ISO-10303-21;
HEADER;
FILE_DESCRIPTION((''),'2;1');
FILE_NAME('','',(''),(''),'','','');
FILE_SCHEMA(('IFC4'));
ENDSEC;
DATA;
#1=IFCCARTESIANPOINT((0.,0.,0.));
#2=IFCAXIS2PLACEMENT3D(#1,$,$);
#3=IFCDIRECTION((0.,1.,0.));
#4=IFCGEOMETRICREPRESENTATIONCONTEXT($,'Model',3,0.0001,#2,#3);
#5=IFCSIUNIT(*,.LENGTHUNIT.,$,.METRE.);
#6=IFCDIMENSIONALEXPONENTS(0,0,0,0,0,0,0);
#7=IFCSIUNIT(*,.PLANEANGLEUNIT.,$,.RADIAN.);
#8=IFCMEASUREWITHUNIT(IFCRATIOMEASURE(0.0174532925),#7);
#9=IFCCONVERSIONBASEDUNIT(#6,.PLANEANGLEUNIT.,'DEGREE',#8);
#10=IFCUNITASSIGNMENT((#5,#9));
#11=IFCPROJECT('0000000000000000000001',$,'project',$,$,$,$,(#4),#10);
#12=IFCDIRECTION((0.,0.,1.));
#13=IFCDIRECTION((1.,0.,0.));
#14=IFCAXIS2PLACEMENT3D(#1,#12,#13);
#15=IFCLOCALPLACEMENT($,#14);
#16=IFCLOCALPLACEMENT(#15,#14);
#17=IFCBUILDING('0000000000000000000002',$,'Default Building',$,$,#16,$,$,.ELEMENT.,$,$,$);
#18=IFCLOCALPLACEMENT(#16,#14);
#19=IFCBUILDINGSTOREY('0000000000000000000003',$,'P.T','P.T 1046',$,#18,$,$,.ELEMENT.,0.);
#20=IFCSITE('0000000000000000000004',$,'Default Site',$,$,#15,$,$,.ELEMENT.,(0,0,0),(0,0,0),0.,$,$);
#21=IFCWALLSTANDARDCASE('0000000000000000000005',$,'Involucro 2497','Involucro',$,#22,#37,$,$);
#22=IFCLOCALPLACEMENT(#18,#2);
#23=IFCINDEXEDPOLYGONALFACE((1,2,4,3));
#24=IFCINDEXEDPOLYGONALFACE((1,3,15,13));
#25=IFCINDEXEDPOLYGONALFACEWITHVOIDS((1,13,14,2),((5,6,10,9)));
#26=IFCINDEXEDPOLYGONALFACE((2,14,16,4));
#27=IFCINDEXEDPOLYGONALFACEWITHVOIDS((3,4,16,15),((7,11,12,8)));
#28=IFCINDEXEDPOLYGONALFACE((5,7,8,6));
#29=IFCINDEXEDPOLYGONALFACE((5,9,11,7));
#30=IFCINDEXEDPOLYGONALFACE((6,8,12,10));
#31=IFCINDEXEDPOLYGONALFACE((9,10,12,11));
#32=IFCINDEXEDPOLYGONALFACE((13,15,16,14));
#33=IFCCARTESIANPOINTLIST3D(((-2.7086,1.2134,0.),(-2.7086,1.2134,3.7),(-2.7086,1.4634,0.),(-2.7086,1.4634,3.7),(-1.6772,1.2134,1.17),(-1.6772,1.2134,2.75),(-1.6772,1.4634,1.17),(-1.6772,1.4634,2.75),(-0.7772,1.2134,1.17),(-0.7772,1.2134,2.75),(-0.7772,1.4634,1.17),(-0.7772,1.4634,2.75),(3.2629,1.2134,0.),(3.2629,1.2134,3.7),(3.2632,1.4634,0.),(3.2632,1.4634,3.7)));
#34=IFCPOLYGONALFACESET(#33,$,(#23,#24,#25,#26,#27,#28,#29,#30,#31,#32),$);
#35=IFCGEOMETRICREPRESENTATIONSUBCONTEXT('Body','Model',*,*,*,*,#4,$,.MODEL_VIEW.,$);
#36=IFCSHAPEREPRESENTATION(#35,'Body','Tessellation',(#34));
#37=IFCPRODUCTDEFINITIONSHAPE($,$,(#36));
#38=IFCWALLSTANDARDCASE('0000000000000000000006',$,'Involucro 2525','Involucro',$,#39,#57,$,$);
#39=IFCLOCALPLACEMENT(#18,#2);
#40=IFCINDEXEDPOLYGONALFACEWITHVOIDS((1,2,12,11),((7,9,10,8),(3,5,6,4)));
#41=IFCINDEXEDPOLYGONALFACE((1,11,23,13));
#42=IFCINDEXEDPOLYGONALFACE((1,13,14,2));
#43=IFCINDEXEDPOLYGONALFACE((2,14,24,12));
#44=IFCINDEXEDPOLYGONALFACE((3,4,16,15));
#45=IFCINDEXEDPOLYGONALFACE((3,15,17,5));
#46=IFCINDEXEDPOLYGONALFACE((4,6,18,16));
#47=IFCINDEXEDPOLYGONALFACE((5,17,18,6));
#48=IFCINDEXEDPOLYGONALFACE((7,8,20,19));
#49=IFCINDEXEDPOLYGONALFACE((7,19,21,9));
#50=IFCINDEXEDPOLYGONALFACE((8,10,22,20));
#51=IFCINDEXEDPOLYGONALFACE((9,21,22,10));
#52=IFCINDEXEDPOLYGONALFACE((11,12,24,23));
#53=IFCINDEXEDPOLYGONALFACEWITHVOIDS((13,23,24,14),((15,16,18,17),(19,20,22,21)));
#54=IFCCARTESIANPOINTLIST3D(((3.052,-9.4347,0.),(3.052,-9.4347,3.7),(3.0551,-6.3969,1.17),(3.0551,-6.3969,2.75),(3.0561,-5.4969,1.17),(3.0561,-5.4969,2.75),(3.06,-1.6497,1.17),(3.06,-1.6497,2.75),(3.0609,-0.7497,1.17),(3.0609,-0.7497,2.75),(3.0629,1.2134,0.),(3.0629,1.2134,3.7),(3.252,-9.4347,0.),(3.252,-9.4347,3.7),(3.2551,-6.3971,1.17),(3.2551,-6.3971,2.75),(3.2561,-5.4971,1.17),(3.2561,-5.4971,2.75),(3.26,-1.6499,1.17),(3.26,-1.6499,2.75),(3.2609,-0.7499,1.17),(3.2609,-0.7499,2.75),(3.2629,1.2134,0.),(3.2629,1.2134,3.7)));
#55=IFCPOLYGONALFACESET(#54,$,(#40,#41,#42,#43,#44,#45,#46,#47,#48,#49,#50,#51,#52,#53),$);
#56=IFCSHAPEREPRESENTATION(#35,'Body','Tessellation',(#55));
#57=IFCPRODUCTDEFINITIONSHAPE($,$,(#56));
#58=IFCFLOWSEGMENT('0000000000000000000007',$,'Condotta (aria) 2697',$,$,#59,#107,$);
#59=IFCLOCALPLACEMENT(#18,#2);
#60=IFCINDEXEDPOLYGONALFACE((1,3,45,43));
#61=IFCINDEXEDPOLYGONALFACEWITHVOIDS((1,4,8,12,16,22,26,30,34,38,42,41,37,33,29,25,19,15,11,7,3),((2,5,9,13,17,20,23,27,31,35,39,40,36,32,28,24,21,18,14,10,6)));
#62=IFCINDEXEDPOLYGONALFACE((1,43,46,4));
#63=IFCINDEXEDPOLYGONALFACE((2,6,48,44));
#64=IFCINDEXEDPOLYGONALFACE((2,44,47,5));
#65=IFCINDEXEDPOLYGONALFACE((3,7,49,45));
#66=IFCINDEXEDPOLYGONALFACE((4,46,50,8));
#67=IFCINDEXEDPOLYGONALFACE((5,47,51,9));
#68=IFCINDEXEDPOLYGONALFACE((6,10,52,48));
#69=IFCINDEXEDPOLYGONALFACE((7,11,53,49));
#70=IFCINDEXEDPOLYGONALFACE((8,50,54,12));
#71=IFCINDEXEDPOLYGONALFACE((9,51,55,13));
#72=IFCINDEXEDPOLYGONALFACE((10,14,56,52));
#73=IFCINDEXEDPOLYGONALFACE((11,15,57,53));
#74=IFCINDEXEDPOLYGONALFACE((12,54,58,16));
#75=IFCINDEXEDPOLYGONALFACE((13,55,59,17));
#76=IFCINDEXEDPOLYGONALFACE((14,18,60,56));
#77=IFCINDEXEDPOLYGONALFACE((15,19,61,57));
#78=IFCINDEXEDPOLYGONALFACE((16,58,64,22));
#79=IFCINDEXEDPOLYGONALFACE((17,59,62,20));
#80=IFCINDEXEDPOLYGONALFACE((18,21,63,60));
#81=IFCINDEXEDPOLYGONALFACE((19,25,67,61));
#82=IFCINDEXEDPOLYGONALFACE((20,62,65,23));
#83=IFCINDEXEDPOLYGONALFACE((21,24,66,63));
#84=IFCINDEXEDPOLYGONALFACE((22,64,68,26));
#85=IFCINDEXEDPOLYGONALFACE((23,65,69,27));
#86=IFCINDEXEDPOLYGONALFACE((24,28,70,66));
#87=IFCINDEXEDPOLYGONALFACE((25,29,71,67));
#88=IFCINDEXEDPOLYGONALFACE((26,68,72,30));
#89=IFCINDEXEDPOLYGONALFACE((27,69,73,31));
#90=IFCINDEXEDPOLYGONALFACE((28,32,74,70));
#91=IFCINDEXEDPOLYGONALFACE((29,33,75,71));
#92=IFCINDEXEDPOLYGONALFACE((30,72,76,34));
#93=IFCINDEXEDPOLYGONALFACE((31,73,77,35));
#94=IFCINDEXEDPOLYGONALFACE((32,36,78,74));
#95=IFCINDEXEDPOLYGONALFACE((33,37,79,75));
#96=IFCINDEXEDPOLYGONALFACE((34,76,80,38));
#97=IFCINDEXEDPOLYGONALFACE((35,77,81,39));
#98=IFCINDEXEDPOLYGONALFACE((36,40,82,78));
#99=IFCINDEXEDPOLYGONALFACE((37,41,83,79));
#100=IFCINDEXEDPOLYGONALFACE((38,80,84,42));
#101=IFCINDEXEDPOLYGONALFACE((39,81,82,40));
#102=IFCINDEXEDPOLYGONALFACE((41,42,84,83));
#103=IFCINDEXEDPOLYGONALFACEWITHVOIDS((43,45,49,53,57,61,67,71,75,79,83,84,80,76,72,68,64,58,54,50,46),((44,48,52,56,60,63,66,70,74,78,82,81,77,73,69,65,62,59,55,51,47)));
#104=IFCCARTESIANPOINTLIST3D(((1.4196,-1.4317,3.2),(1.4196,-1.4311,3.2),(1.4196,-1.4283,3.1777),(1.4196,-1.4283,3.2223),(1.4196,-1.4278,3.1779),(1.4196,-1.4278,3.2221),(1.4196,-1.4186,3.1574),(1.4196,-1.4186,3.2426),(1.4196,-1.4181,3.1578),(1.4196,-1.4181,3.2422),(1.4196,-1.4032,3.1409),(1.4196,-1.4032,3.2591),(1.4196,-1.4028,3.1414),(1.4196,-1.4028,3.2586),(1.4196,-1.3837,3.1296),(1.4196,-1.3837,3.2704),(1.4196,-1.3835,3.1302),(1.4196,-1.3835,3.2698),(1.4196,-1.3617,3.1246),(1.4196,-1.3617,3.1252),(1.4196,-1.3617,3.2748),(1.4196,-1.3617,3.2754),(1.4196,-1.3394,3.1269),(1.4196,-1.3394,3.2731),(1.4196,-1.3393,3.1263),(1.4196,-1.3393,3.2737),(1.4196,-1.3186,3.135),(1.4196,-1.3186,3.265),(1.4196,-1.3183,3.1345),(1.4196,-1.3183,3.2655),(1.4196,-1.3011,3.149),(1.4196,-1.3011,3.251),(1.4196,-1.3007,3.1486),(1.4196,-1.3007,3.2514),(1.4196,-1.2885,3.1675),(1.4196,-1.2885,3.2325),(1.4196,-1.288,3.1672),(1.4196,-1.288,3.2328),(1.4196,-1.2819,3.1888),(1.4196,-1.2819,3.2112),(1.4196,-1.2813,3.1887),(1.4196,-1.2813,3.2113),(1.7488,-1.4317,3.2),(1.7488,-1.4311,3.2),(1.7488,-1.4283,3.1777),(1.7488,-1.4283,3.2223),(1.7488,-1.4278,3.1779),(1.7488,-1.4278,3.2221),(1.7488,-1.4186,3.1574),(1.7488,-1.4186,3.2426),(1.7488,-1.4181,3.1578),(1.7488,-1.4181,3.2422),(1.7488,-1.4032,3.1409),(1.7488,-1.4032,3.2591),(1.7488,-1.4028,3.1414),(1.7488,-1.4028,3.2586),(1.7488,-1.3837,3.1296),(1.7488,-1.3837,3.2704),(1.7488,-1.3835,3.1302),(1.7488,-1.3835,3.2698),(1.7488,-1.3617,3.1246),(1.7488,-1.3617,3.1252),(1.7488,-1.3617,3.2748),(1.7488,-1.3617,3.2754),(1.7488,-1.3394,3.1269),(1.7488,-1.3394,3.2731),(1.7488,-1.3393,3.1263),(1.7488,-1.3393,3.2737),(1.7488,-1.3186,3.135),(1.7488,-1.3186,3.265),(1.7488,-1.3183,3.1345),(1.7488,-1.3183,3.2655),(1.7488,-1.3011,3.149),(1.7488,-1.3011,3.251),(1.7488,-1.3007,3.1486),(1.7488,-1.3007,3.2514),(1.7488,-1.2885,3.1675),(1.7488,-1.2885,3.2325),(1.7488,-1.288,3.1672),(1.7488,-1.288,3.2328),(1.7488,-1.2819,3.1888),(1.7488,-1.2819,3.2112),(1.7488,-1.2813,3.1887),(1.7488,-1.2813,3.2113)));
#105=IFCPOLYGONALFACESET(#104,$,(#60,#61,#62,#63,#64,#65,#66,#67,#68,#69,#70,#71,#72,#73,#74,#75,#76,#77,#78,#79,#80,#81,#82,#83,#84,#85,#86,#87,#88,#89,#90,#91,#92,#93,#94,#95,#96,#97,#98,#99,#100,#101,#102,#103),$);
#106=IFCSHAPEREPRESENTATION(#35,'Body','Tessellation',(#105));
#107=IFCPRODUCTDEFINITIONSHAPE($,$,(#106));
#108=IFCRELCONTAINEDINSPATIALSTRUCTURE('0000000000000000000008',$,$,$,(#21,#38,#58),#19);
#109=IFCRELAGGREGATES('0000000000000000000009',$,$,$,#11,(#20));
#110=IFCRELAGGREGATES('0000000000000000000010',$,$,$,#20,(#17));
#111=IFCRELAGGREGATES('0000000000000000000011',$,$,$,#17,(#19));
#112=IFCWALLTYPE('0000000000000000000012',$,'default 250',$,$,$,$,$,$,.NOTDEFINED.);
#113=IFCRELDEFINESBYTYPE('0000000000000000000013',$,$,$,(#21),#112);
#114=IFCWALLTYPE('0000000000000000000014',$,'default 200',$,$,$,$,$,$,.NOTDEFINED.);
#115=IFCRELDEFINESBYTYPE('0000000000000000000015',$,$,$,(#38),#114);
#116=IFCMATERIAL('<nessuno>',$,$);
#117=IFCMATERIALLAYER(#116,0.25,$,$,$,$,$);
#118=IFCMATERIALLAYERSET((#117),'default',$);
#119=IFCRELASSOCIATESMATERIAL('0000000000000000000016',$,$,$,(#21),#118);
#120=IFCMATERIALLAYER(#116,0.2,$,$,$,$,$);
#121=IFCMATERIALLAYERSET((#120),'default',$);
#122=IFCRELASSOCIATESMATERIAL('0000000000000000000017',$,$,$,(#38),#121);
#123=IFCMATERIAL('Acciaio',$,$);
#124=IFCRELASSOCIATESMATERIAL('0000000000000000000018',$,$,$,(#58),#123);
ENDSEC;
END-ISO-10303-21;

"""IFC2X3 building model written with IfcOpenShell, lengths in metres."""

from ifc_helpers import new_model, entity, si_unit, converted_unit, direction, frame, origin, origin_with_axes, origin_2d_with_axis, place, context, subcontext, project, spatial, polyline, hollow_circle, outline, extrude, shape, source, transform, mapped, material, layer, layer_set, layer_usage, type_object, element, save


model = new_model("IFC2X3")

# Units and contexts
model_context = context("Model", 3, precision=0.0001, world=origin(), true_north=direction((0.0, 1.0, 0.0)))
body_context = subcontext(model_context, "Body", "Model", "MODEL_VIEW")
profile_context = subcontext(model_context, "Profile", "Model", "MODEL_VIEW")
footprint_context = subcontext(model_context, "FootPrint", "Model", "MODEL_VIEW")
ifc_project = project(units=[si_unit("LENGTHUNIT", "METRE"), converted_unit("PLANEANGLEUNIT", "DEGREE", entity("IfcRatioMeasure", 0.0174532925), si_unit("PLANEANGLEUNIT", "RADIAN"), dimensions=[0, 0, 0, 0, 0, 0, 0])], contexts=[model_context])

# Site, building, storey
site_placement = place(None, origin_with_axes())
site = spatial("IfcSite", under=ifc_project, at=site_placement, Name="Default Site", CompositionType="ELEMENT", RefLatitude=(0, 0, 0), RefLongitude=(0, 0, 0), RefElevation=0.0)
building_placement = place(site_placement, origin_with_axes())
building = spatial("IfcBuilding", under=site, at=building_placement, Name="Default Building", CompositionType="ELEMENT")
storey_placement = place(building_placement, frame((0.0, 0.0, 0.0), z_axis=(0.0, 0.0, 1.0), x_axis=(1.0, 0.0, 0.0)))
storey = spatial("IfcBuildingStorey", under=building, at=storey_placement, Name="P.T", Description="P.T 1046", CompositionType="ELEMENT", Elevation=0.0)

# Wall, opening
ifc_material_1 = material(Name="<nessuno>")
ifc_layer_1 = layer(ifc_material_1, 0.25)
ifc_layer_set_1 = layer_set([ifc_layer_1], Name="default")
ifc_layer_usage_1 = layer_usage(ifc_layer_set_1, "AXIS2", "POSITIVE", -0.125)
wall_type_1 = type_object("IfcWallType", Name="default 250", PredefinedType="NOTDEFINED")
wall_1_placement = place(storey_placement, frame((-2.798, 1.3384, 0.0), z_axis=(0.0, 0.0, 1.0), x_axis=(1.0, 0.0, 0.0)))
wall_1 = element("IfcWallStandardCase", 1, at=wall_1_placement, inside=storey, type_object=wall_type_1, material=ifc_layer_usage_1, Name="Involucro 2497", Description="Involucro", context=body_context, shape_type="SweptSolid", body=[
    extrude(outline(polyline([(6.0612, 0.125), (0.0894, 0.125), (0.0894, -0.125), (6.0609, -0.125), (6.0612, 0.125)])), origin_with_axes(), (0.0, 0.0, 1.0), 3.7),
])
opening_1_placement = place(wall_1_placement, frame((1.1208, 0.0, 0.0), z_axis=(0.0, 0.0, 1.0), x_axis=(1.0, 0.0, 0.0)))
cartesian_point_1 = entity("IfcCartesianPoint", [0.9, 0.0, 2.75])
cartesian_point_2 = entity("IfcCartesianPoint", [0.9, 0.125])
element("IfcOpeningElement", 2, at=opening_1_placement, cuts=wall_1, ObjectType="Opening", shapes=[
    shape(body_context, "Body", "SweptSolid", [extrude(outline(polyline([(0.0, 2.75), (0.0, 1.17), (0.9, 1.17), (0.9, 2.75), (0.0, 2.75)])), frame((0.0, 0.125, 0.0), z_axis=(0.0, -1.0, 0.0), x_axis=(1.0, 0.0, 0.0)), (0.0, 0.0, 1.0), 0.25)]),
    shape(profile_context, "Profile", "GeometricCurveSet", [entity("IfcGeometricCurveSet", [entity("IfcPolyline", [cartesian_point_1, entity("IfcCartesianPoint", [0.9, 0.0, 1.2]), entity("IfcCartesianPoint", [0.0, 0.0, 1.2]), entity("IfcCartesianPoint", [0.0, 0.0, 2.75]), cartesian_point_1])])]),
    shape(footprint_context, "FootPrint", "GeometricCurveSet", [entity("IfcGeometricCurveSet", [entity("IfcPolyline", [cartesian_point_2, entity("IfcCartesianPoint", [0.0, 0.125]), entity("IfcCartesianPoint", [0.0, -0.125]), entity("IfcCartesianPoint", [0.9, -0.125]), cartesian_point_2])])]),
])

# Shared definitions
ifc_layer_2 = layer(ifc_material_1, 0.2)
ifc_layer_set_2 = layer_set([ifc_layer_2], Name="default")
wall_type_2 = type_object("IfcWallType", Name="default 200", PredefinedType="NOTDEFINED")

# Wall, openings
ifc_layer_usage_2 = layer_usage(ifc_layer_set_2, "AXIS2", "POSITIVE", -0.1)
wall_2_placement = place(storey_placement, frame((3.1519, -9.5347, 0.0), z_axis=(0.0, 0.0, 1.0), x_axis=(0.001024, 0.999999, 0.0)))
wall_2 = element("IfcWallStandardCase", 3, at=wall_2_placement, inside=storey, type_object=wall_type_2, material=ifc_layer_usage_2, Name="Involucro 2525", Description="Involucro", context=body_context, shape_type="SweptSolid", body=[
    extrude(outline(polyline([(10.748, 0.1), (0.0999, 0.1), (0.1001, -0.1), (10.7482, -0.1), (10.748, 0.1)])), frame((0.0, 0.0, 0.0), z_axis=(0.0, 0.0, 1.0), x_axis=(1.0, 0.0, 0.0)), (0.0, 0.0, 1.0), 3.7),
])
opening_2_placement = place(wall_2_placement, frame((3.1376, 0.0, 0.0), z_axis=(0.0, 0.0, 1.0), x_axis=(-1.0, 0.0, 0.0)))
cartesian_point_3 = entity("IfcCartesianPoint", [0.0, 0.0, 2.75])
cartesian_point_4 = entity("IfcCartesianPoint", [-0.9, -0.1])
element("IfcOpeningElement", 4, at=opening_2_placement, cuts=wall_2, ObjectType="Opening", shapes=[
    shape(body_context, "Body", "SweptSolid", [extrude(outline(polyline([(0.0, 2.75), (0.0, 1.17), (0.9, 1.17), (0.9, 2.75), (0.0, 2.75)])), frame((0.0, -0.1, 0.0), z_axis=(0.0, 1.0, 0.0), x_axis=(-1.0, 0.0, 0.0)), (0.0, 0.0, 1.0), 0.2)]),
    shape(profile_context, "Profile", "GeometricCurveSet", [entity("IfcGeometricCurveSet", [entity("IfcPolyline", [cartesian_point_3, entity("IfcCartesianPoint", [0.0, 0.0, 1.2]), entity("IfcCartesianPoint", [-0.9, 0.0, 1.2]), entity("IfcCartesianPoint", [-0.9, 0.0, 2.75]), cartesian_point_3])])]),
    shape(footprint_context, "FootPrint", "GeometricCurveSet", [entity("IfcGeometricCurveSet", [entity("IfcPolyline", [cartesian_point_4, entity("IfcCartesianPoint", [0.0, -0.1]), entity("IfcCartesianPoint", [0.0, 0.1]), entity("IfcCartesianPoint", [-0.9, 0.1]), cartesian_point_4])])]),
])
opening_3_placement = place(wall_2_placement, frame((7.8849, 0.0, 0.0), z_axis=(0.0, 0.0, 1.0), x_axis=(-1.0, 0.0, 0.0)))
cartesian_point_5 = entity("IfcCartesianPoint", [0.0, 0.0, 2.75])
cartesian_point_6 = entity("IfcCartesianPoint", [-0.9, -0.1])
element("IfcOpeningElement", 5, at=opening_3_placement, cuts=wall_2, ObjectType="Opening", shapes=[
    shape(body_context, "Body", "SweptSolid", [extrude(outline(polyline([(0.0, 2.75), (0.0, 1.17), (0.9, 1.17), (0.9, 2.75), (0.0, 2.75)])), frame((0.0, -0.1, 0.0), z_axis=(0.0, 1.0, 0.0), x_axis=(-1.0, 0.0, 0.0)), (0.0, 0.0, 1.0), 0.2)]),
    shape(profile_context, "Profile", "GeometricCurveSet", [entity("IfcGeometricCurveSet", [entity("IfcPolyline", [cartesian_point_5, entity("IfcCartesianPoint", [0.0, 0.0, 1.2]), entity("IfcCartesianPoint", [-0.9, 0.0, 1.2]), entity("IfcCartesianPoint", [-0.9, 0.0, 2.75]), cartesian_point_5])])]),
    shape(footprint_context, "FootPrint", "GeometricCurveSet", [entity("IfcGeometricCurveSet", [entity("IfcPolyline", [cartesian_point_6, entity("IfcCartesianPoint", [0.0, -0.1]), entity("IfcCartesianPoint", [0.0, 0.1]), entity("IfcCartesianPoint", [-0.9, 0.1]), cartesian_point_6])])]),
])

# Flow segment
ifc_material_2 = material(Name="Acciaio")
shared_shape_1 = source(origin_with_axes(), body_context, "Body", "SweptSolid", [
    extrude(hollow_circle(Radius=0.0756, WallThickness=0.0006, at=origin_2d_with_axis()), origin_with_axes(), (0.0, 0.0, 1.0), 1.0),
])
shared_shape_2 = source(origin_with_axes(), body_context, "Body", "SweptSolid", [
    extrude(hollow_circle(Radius=0.1006, WallThickness=0.025, at=origin_2d_with_axis()), origin_with_axes(), (0.0, 0.0, 1.0), 1.0),
])
for number, where, z_axis, x_axis, name in (
    (6, (1.5842, -1.3561, 3.2), (-1.0, 0.0, 0.0), (0.0, -1.0, 0.0), "Condotta (aria) 2697"),
):
    element("IfcFlowSegment", number, at=place(storey_placement, frame(where, z_axis=z_axis, x_axis=x_axis)), inside=storey, material=ifc_material_2, Name=name, shapes=[
        shape(body_context, "Body", "MappedRepresentation", [mapped(shared_shape_1, transform((0.0, 0.0, -0.1646), x_axis=(1.0, 0.0, 0.0), y_axis=(0.0, 1.0, 0.0), z_axis=(0.0, 0.0, 1.0), scale=1.0, scale2=1.0, scale3=0.329256, uniform=False))]),
        shape(body_context, "Body", "MappedRepresentation", [mapped(shared_shape_2, transform((0.0, 0.0, 0.1634), x_axis=(1.0, 0.0, 0.0), y_axis=(0.0, 1.0, 0.0), z_axis=(0.0, 0.0, 1.0), scale=1.0, scale2=1.0, scale3=0.0012, uniform=False))]),
        shape(body_context, "Body", "MappedRepresentation", [mapped(shared_shape_2, transform((0.0, 0.0, -0.1634), x_axis=(-1.0, 0.0, 0.0), y_axis=(0.0, 1.0, 0.0), z_axis=(0.0, 0.0, -1.0), scale=1.0, scale2=1.0, scale3=0.0012, uniform=False))]),
    ])

save(model, "model.ifc")
